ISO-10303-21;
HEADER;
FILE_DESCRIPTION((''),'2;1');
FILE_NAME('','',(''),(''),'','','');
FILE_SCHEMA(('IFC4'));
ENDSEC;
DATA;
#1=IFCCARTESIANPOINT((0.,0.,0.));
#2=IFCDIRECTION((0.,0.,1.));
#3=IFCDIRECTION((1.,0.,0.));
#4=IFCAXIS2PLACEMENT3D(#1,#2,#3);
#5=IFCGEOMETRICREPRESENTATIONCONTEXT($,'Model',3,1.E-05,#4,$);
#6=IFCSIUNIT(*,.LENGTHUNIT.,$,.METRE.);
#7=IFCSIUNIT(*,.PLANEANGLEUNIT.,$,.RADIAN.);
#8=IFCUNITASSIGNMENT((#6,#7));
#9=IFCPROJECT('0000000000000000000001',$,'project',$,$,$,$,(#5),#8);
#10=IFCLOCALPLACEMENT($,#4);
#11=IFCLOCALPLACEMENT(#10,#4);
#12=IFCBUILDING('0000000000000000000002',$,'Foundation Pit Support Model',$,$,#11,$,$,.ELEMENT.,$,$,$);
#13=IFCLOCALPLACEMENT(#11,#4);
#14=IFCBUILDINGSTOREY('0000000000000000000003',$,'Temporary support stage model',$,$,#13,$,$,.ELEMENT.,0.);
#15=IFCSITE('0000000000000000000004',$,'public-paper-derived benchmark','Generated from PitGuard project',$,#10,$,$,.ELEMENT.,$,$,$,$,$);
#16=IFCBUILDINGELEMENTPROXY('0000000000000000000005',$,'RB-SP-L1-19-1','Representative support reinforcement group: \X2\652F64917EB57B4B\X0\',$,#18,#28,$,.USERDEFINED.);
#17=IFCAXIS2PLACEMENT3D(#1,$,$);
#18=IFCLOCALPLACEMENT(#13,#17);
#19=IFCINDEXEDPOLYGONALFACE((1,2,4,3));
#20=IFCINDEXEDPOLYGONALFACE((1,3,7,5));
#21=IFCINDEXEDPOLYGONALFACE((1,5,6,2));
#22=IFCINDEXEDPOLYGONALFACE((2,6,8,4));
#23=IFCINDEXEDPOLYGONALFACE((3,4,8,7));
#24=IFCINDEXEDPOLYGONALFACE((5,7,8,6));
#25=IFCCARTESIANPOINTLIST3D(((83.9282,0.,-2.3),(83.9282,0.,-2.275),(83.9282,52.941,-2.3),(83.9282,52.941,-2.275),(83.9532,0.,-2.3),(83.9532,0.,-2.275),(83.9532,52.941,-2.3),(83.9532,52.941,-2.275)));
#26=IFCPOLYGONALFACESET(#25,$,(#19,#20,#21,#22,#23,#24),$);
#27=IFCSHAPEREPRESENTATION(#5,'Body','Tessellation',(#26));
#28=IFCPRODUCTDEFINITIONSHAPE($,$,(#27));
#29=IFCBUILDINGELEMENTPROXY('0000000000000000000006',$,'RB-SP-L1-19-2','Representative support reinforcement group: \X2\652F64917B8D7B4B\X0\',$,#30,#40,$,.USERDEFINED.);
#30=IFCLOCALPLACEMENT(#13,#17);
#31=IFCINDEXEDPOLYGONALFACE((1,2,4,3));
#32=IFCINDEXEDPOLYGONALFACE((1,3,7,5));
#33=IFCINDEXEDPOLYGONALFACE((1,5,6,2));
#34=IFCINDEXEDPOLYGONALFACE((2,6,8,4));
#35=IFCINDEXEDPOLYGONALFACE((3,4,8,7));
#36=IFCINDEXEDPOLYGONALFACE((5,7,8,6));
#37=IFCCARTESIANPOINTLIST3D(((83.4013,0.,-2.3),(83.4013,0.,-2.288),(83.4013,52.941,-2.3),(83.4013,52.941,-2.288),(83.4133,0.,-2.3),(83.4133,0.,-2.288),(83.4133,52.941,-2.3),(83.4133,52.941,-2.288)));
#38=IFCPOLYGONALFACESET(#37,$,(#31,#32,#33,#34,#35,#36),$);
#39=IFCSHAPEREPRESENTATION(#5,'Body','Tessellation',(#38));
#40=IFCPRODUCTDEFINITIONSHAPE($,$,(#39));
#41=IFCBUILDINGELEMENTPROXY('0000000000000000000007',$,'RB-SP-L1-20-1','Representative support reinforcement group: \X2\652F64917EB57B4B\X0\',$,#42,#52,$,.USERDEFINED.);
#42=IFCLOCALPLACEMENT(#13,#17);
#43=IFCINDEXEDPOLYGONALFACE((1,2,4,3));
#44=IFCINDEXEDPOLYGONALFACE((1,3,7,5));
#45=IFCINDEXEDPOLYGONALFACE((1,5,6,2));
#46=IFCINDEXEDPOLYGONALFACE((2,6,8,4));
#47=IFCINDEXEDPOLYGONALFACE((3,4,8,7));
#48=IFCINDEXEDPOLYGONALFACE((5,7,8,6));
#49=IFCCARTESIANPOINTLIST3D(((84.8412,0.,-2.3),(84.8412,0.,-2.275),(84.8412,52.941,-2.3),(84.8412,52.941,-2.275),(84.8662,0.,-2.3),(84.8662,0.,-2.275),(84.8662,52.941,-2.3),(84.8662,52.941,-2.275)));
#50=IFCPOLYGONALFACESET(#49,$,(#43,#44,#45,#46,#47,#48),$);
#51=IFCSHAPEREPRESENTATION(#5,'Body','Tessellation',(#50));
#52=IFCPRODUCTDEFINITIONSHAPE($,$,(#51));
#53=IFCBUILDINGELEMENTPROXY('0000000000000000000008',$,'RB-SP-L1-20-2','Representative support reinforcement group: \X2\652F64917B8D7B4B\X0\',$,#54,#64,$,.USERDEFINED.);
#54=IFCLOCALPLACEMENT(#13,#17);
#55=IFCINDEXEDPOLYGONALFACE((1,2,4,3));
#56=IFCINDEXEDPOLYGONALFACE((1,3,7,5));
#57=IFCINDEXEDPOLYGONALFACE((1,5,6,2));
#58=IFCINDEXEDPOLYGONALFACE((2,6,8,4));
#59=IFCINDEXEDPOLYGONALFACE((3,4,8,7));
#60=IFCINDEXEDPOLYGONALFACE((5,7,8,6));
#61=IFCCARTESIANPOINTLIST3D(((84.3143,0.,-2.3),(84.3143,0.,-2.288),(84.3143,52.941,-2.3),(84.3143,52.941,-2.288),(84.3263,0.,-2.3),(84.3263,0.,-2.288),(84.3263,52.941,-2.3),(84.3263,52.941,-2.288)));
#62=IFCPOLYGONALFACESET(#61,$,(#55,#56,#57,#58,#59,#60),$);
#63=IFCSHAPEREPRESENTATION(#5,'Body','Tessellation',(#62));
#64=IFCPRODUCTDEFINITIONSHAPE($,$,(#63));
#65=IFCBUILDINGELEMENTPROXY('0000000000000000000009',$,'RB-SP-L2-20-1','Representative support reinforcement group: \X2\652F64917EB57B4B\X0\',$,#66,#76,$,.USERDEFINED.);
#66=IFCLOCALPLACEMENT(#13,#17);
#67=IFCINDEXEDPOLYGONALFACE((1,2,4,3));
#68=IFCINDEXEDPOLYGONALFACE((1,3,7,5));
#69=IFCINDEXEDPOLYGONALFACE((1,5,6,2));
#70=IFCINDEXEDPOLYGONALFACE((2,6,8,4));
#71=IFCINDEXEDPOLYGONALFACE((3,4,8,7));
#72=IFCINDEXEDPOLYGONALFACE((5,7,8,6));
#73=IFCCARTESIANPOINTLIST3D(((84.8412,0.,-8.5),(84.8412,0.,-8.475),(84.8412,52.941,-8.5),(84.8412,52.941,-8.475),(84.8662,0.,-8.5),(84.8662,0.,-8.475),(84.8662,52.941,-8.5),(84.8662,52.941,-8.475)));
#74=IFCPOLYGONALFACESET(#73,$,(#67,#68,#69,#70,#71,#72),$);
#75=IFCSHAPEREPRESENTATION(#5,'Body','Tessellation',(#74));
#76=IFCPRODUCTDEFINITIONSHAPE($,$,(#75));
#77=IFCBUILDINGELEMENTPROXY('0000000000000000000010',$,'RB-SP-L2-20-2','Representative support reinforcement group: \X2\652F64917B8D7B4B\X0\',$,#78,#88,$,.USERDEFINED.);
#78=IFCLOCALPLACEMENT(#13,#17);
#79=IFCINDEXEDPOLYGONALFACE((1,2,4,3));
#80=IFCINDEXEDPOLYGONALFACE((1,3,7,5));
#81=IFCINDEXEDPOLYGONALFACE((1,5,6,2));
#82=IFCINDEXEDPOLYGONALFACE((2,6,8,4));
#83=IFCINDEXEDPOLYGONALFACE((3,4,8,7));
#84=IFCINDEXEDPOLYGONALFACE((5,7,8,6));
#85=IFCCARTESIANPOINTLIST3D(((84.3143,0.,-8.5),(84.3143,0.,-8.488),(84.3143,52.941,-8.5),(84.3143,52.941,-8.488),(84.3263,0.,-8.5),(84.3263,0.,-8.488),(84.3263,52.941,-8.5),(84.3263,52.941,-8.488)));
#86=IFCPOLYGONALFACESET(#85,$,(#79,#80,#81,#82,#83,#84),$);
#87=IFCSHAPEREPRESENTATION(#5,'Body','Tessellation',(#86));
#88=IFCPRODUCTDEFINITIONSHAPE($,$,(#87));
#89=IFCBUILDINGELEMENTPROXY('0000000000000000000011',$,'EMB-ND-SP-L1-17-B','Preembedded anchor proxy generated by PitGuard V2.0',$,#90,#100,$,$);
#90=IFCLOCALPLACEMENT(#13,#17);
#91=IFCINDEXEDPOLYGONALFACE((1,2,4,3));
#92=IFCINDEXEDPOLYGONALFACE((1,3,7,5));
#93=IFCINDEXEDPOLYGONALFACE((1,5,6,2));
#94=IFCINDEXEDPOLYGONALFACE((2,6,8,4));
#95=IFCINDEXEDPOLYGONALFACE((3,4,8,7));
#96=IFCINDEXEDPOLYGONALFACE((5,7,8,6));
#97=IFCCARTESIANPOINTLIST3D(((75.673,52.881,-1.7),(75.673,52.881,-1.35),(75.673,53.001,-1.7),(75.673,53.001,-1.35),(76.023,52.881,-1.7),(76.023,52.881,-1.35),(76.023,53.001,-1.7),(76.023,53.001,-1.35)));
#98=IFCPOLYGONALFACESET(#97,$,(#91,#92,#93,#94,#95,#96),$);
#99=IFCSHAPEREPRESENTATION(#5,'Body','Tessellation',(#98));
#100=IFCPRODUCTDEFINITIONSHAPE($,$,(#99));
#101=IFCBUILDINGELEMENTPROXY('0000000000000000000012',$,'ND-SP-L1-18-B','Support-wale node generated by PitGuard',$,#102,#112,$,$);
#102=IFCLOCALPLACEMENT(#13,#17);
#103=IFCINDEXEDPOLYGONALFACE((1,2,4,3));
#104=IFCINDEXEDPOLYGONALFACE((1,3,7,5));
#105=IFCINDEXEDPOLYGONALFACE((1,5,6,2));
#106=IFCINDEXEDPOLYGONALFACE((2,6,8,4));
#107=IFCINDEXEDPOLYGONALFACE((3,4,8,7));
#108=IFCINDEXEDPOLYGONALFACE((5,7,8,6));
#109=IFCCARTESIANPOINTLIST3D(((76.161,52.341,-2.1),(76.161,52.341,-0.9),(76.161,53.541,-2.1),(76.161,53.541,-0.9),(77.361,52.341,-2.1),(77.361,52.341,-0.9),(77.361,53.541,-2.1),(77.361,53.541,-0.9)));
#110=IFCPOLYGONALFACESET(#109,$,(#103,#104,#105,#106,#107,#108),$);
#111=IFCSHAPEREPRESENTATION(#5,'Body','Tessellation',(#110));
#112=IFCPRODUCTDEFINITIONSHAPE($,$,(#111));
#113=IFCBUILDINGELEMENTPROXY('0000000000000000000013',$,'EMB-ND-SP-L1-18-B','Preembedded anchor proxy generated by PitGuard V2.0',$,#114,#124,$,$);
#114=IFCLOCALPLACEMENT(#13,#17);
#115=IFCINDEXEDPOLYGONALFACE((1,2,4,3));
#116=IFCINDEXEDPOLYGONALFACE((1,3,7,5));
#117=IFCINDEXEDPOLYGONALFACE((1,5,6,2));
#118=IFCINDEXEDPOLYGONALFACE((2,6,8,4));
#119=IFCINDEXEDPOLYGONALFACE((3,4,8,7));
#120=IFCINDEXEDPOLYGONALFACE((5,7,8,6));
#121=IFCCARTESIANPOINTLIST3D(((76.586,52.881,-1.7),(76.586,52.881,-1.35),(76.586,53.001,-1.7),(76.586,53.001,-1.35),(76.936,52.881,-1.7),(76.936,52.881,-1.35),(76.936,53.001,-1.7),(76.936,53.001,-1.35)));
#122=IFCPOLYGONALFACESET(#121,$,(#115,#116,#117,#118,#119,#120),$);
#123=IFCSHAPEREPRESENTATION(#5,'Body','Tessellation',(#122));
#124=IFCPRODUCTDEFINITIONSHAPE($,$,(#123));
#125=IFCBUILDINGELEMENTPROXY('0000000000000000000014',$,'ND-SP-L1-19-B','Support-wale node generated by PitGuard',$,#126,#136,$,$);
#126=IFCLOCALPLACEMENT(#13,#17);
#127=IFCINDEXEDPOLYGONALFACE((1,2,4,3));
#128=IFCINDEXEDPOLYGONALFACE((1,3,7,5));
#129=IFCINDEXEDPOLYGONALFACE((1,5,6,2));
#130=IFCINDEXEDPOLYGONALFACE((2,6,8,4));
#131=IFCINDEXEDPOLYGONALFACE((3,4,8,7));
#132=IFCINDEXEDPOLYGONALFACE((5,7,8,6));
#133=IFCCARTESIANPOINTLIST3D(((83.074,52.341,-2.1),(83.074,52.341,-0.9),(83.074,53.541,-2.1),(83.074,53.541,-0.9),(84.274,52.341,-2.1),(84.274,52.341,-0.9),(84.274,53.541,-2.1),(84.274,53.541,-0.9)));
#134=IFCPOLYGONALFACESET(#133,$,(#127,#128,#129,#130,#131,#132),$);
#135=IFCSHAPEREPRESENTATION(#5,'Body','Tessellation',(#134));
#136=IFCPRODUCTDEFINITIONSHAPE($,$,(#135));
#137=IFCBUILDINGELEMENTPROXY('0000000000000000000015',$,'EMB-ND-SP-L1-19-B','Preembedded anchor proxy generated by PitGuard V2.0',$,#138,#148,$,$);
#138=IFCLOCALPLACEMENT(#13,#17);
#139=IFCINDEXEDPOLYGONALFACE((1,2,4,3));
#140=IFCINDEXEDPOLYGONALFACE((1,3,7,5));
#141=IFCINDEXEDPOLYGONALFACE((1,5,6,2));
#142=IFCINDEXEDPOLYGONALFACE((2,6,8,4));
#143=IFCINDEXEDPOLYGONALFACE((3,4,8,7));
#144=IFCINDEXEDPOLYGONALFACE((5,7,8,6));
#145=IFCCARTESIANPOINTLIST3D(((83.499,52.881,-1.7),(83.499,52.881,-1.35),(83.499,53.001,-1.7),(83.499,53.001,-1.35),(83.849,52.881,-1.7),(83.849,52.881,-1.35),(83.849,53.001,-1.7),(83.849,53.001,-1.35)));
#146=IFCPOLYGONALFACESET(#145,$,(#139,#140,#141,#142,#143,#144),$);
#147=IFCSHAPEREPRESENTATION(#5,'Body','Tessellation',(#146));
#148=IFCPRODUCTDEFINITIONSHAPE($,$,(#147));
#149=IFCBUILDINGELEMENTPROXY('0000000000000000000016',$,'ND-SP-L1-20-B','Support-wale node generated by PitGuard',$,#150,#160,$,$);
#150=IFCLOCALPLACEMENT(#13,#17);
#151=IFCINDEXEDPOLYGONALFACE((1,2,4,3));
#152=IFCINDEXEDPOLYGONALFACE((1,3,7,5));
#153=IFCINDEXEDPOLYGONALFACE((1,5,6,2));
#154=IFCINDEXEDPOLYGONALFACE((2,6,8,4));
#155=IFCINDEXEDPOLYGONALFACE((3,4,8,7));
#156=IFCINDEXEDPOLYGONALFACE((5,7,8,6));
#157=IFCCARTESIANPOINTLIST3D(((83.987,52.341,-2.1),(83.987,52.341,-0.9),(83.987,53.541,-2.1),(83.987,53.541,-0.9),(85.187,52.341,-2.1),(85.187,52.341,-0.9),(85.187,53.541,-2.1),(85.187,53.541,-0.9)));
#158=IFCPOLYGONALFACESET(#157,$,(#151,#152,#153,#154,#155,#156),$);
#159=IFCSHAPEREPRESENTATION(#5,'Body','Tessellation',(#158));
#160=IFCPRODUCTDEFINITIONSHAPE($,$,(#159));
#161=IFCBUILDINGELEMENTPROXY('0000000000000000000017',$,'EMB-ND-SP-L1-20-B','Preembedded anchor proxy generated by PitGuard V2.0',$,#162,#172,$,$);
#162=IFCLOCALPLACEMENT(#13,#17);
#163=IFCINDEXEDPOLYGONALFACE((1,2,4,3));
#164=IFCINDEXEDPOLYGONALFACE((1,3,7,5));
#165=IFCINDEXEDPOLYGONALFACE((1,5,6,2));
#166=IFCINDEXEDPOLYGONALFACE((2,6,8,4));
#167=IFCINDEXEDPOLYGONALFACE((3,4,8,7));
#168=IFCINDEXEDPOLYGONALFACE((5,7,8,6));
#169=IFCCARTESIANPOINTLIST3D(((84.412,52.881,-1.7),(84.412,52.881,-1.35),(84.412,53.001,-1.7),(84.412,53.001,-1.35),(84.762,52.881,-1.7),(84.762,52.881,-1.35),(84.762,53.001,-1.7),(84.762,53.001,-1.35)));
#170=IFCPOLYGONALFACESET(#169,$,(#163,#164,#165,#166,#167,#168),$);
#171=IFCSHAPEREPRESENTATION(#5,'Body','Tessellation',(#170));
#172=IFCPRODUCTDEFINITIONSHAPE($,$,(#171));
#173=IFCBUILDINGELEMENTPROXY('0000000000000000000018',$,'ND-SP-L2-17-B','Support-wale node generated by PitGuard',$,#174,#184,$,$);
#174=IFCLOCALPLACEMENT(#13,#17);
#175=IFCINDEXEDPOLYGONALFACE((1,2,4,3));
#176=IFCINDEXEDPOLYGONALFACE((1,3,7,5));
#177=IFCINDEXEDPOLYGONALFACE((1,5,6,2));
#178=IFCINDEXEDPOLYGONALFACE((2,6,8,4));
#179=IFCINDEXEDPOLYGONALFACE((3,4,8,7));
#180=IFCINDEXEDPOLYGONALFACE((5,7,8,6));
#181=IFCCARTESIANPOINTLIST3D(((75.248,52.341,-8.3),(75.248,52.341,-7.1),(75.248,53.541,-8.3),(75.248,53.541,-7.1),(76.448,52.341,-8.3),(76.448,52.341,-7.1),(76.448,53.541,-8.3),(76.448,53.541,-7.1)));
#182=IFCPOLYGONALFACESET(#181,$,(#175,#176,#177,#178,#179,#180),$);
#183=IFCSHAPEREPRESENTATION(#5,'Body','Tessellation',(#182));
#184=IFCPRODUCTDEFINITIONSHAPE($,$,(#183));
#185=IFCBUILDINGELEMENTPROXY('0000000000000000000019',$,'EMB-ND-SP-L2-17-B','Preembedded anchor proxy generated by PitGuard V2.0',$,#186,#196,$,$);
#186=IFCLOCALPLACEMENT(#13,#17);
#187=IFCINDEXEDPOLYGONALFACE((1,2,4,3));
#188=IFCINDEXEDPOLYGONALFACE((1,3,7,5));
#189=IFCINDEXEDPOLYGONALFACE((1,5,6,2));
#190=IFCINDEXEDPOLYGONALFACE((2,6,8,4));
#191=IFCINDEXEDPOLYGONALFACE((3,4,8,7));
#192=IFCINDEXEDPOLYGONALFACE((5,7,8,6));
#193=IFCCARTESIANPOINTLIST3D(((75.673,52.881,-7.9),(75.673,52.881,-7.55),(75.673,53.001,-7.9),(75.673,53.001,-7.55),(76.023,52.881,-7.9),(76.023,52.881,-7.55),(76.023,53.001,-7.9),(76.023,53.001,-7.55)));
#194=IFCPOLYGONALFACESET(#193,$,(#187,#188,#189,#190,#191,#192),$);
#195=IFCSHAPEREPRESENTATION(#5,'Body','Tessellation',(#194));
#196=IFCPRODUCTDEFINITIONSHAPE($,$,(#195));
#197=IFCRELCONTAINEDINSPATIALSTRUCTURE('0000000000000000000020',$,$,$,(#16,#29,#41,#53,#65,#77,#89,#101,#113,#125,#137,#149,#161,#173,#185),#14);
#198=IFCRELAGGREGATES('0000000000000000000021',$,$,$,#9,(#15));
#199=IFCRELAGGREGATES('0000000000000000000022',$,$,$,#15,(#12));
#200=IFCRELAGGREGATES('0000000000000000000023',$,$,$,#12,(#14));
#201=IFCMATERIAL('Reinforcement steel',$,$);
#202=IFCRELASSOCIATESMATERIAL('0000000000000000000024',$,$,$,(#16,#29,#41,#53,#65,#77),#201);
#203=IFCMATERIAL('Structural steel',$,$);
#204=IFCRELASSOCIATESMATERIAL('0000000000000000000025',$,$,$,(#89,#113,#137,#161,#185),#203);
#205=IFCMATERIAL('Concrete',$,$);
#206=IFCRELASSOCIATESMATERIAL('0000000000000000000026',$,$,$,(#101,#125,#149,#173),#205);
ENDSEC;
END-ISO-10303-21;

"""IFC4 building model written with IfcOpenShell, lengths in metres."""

from ifc_helpers import new_model, si_unit, frame, origin_with_axes, origin_2d, place, context, project, spatial, rectangle, extrude, material, element, save


model = new_model("IFC4")

# Units and contexts
model_context = context("Model", 3, precision=1e-05, world=origin_with_axes())
ifc_project = project(units=[si_unit("LENGTHUNIT", "METRE"), si_unit("PLANEANGLEUNIT", "RADIAN")], contexts=[model_context])

# Site, building, storey
site_placement = place(None, origin_with_axes())
site = spatial("IfcSite", under=ifc_project, at=site_placement, Name="public-paper-derived benchmark", Description="Generated from PitGuard project", CompositionType="ELEMENT")
building_placement = place(site_placement, origin_with_axes())
building = spatial("IfcBuilding", under=site, at=building_placement, Name="Foundation Pit Support Model", CompositionType="ELEMENT")
storey_placement = place(building_placement, origin_with_axes())
storey = spatial("IfcBuildingStorey", under=building, at=storey_placement, Name="Temporary support stage model", CompositionType="ELEMENT", Elevation=0.0)

# Shared definitions
ifc_material_1 = material(Name="Concrete")

# Shared definitions
ifc_material_2 = material(Name="Structural steel")

# Building element proxies
ifc_material_3 = material(Name="Reinforcement steel")
proxy_1_placement = place(storey_placement, frame((83.9407, 26.4705, -2.3), z_axis=(0.0, 0.0, 1.0), x_axis=(0.0, 1.0, 0.0)))
element("IfcBuildingElementProxy", 1, at=proxy_1_placement, inside=storey, material=ifc_material_3, Name="RB-SP-L1-19-1", Description="Representative support reinforcement group: 支撑纵筋", PredefinedType="USERDEFINED", context=model_context, shape_type="SweptSolid", body=[
    extrude(rectangle(XDim=52.941, YDim=0.025, at=origin_2d()), origin_with_axes(), (0.0, 0.0, 1.0), 0.025),
])
proxy_2_placement = place(storey_placement, frame((83.4073, 26.4705, -2.3), z_axis=(0.0, 0.0, 1.0), x_axis=(0.0, 1.0, 0.0)))
element("IfcBuildingElementProxy", 2, at=proxy_2_placement, inside=storey, material=ifc_material_3, Name="RB-SP-L1-19-2", Description="Representative support reinforcement group: 支撑箍筋", PredefinedType="USERDEFINED", context=model_context, shape_type="SweptSolid", body=[
    extrude(rectangle(XDim=52.941, YDim=0.012, at=origin_2d()), origin_with_axes(), (0.0, 0.0, 1.0), 0.012),
])
proxy_3_placement = place(storey_placement, frame((84.8537, 26.4705, -2.3), z_axis=(0.0, 0.0, 1.0), x_axis=(0.0, 1.0, 0.0)))
element("IfcBuildingElementProxy", 3, at=proxy_3_placement, inside=storey, material=ifc_material_3, Name="RB-SP-L1-20-1", Description="Representative support reinforcement group: 支撑纵筋", PredefinedType="USERDEFINED", context=model_context, shape_type="SweptSolid", body=[
    extrude(rectangle(XDim=52.941, YDim=0.025, at=origin_2d()), origin_with_axes(), (0.0, 0.0, 1.0), 0.025),
])
proxy_4_placement = place(storey_placement, frame((84.3203, 26.4705, -2.3), z_axis=(0.0, 0.0, 1.0), x_axis=(0.0, 1.0, 0.0)))
element("IfcBuildingElementProxy", 4, at=proxy_4_placement, inside=storey, material=ifc_material_3, Name="RB-SP-L1-20-2", Description="Representative support reinforcement group: 支撑箍筋", PredefinedType="USERDEFINED", context=model_context, shape_type="SweptSolid", body=[
    extrude(rectangle(XDim=52.941, YDim=0.012, at=origin_2d()), origin_with_axes(), (0.0, 0.0, 1.0), 0.012),
])
proxy_5_placement = place(storey_placement, frame((84.8537, 26.4705, -8.5), z_axis=(0.0, 0.0, 1.0), x_axis=(0.0, 1.0, 0.0)))
element("IfcBuildingElementProxy", 5, at=proxy_5_placement, inside=storey, material=ifc_material_3, Name="RB-SP-L2-20-1", Description="Representative support reinforcement group: 支撑纵筋", PredefinedType="USERDEFINED", context=model_context, shape_type="SweptSolid", body=[
    extrude(rectangle(XDim=52.941, YDim=0.025, at=origin_2d()), origin_with_axes(), (0.0, 0.0, 1.0), 0.025),
])
proxy_6_placement = place(storey_placement, frame((84.3203, 26.4705, -8.5), z_axis=(0.0, 0.0, 1.0), x_axis=(0.0, 1.0, 0.0)))
element("IfcBuildingElementProxy", 6, at=proxy_6_placement, inside=storey, material=ifc_material_3, Name="RB-SP-L2-20-2", Description="Representative support reinforcement group: 支撑箍筋", PredefinedType="USERDEFINED", context=model_context, shape_type="SweptSolid", body=[
    extrude(rectangle(XDim=52.941, YDim=0.012, at=origin_2d()), origin_with_axes(), (0.0, 0.0, 1.0), 0.012),
])
proxy_7_placement = place(storey_placement, frame((75.848, 52.941, -1.7), z_axis=(0.0, 0.0, 1.0), x_axis=(1.0, 0.0, 0.0)))
element("IfcBuildingElementProxy", 7, at=proxy_7_placement, inside=storey, material=ifc_material_2, Name="EMB-ND-SP-L1-17-B", Description="Preembedded anchor proxy generated by PitGuard V2.0", context=model_context, shape_type="SweptSolid", body=[
    extrude(rectangle(XDim=0.35, YDim=0.12, at=origin_2d()), origin_with_axes(), (0.0, 0.0, 1.0), 0.35),
])
proxy_8_placement = place(storey_placement, frame((76.761, 52.941, -2.1), z_axis=(0.0, 0.0, 1.0), x_axis=(1.0, 0.0, 0.0)))
element("IfcBuildingElementProxy", 8, at=proxy_8_placement, inside=storey, material=ifc_material_1, Name="ND-SP-L1-18-B", Description="Support-wale node generated by PitGuard", context=model_context, shape_type="SweptSolid", body=[
    extrude(rectangle(XDim=1.2, YDim=1.2, at=origin_2d()), origin_with_axes(), (0.0, 0.0, 1.0), 1.2),
])
proxy_9_placement = place(storey_placement, frame((76.761, 52.941, -1.7), z_axis=(0.0, 0.0, 1.0), x_axis=(1.0, 0.0, 0.0)))
element("IfcBuildingElementProxy", 9, at=proxy_9_placement, inside=storey, material=ifc_material_2, Name="EMB-ND-SP-L1-18-B", Description="Preembedded anchor proxy generated by PitGuard V2.0", context=model_context, shape_type="SweptSolid", body=[
    extrude(rectangle(XDim=0.35, YDim=0.12, at=origin_2d()), origin_with_axes(), (0.0, 0.0, 1.0), 0.35),
])
proxy_10_placement = place(storey_placement, frame((83.674, 52.941, -2.1), z_axis=(0.0, 0.0, 1.0), x_axis=(1.0, 0.0, 0.0)))
element("IfcBuildingElementProxy", 10, at=proxy_10_placement, inside=storey, material=ifc_material_1, Name="ND-SP-L1-19-B", Description="Support-wale node generated by PitGuard", context=model_context, shape_type="SweptSolid", body=[
    extrude(rectangle(XDim=1.2, YDim=1.2, at=origin_2d()), origin_with_axes(), (0.0, 0.0, 1.0), 1.2),
])
proxy_11_placement = place(storey_placement, frame((83.674, 52.941, -1.7), z_axis=(0.0, 0.0, 1.0), x_axis=(1.0, 0.0, 0.0)))
element("IfcBuildingElementProxy", 11, at=proxy_11_placement, inside=storey, material=ifc_material_2, Name="EMB-ND-SP-L1-19-B", Description="Preembedded anchor proxy generated by PitGuard V2.0", context=model_context, shape_type="SweptSolid", body=[
    extrude(rectangle(XDim=0.35, YDim=0.12, at=origin_2d()), origin_with_axes(), (0.0, 0.0, 1.0), 0.35),
])
proxy_12_placement = place(storey_placement, frame((84.587, 52.941, -2.1), z_axis=(0.0, 0.0, 1.0), x_axis=(1.0, 0.0, 0.0)))
element("IfcBuildingElementProxy", 12, at=proxy_12_placement, inside=storey, material=ifc_material_1, Name="ND-SP-L1-20-B", Description="Support-wale node generated by PitGuard", context=model_context, shape_type="SweptSolid", body=[
    extrude(rectangle(XDim=1.2, YDim=1.2, at=origin_2d()), origin_with_axes(), (0.0, 0.0, 1.0), 1.2),
])
proxy_13_placement = place(storey_placement, frame((84.587, 52.941, -1.7), z_axis=(0.0, 0.0, 1.0), x_axis=(1.0, 0.0, 0.0)))
element("IfcBuildingElementProxy", 13, at=proxy_13_placement, inside=storey, material=ifc_material_2, Name="EMB-ND-SP-L1-20-B", Description="Preembedded anchor proxy generated by PitGuard V2.0", context=model_context, shape_type="SweptSolid", body=[
    extrude(rectangle(XDim=0.35, YDim=0.12, at=origin_2d()), origin_with_axes(), (0.0, 0.0, 1.0), 0.35),
])
proxy_14_placement = place(storey_placement, frame((75.848, 52.941, -8.3), z_axis=(0.0, 0.0, 1.0), x_axis=(1.0, 0.0, 0.0)))
element("IfcBuildingElementProxy", 14, at=proxy_14_placement, inside=storey, material=ifc_material_1, Name="ND-SP-L2-17-B", Description="Support-wale node generated by PitGuard", context=model_context, shape_type="SweptSolid", body=[
    extrude(rectangle(XDim=1.2, YDim=1.2, at=origin_2d()), origin_with_axes(), (0.0, 0.0, 1.0), 1.2),
])
proxy_15_placement = place(storey_placement, frame((75.848, 52.941, -7.9), z_axis=(0.0, 0.0, 1.0), x_axis=(1.0, 0.0, 0.0)))
element("IfcBuildingElementProxy", 15, at=proxy_15_placement, inside=storey, material=ifc_material_2, Name="EMB-ND-SP-L2-17-B", Description="Preembedded anchor proxy generated by PitGuard V2.0", context=model_context, shape_type="SweptSolid", body=[
    extrude(rectangle(XDim=0.35, YDim=0.12, at=origin_2d()), origin_with_axes(), (0.0, 0.0, 1.0), 0.35),
])

save(model, "model.ifc")
